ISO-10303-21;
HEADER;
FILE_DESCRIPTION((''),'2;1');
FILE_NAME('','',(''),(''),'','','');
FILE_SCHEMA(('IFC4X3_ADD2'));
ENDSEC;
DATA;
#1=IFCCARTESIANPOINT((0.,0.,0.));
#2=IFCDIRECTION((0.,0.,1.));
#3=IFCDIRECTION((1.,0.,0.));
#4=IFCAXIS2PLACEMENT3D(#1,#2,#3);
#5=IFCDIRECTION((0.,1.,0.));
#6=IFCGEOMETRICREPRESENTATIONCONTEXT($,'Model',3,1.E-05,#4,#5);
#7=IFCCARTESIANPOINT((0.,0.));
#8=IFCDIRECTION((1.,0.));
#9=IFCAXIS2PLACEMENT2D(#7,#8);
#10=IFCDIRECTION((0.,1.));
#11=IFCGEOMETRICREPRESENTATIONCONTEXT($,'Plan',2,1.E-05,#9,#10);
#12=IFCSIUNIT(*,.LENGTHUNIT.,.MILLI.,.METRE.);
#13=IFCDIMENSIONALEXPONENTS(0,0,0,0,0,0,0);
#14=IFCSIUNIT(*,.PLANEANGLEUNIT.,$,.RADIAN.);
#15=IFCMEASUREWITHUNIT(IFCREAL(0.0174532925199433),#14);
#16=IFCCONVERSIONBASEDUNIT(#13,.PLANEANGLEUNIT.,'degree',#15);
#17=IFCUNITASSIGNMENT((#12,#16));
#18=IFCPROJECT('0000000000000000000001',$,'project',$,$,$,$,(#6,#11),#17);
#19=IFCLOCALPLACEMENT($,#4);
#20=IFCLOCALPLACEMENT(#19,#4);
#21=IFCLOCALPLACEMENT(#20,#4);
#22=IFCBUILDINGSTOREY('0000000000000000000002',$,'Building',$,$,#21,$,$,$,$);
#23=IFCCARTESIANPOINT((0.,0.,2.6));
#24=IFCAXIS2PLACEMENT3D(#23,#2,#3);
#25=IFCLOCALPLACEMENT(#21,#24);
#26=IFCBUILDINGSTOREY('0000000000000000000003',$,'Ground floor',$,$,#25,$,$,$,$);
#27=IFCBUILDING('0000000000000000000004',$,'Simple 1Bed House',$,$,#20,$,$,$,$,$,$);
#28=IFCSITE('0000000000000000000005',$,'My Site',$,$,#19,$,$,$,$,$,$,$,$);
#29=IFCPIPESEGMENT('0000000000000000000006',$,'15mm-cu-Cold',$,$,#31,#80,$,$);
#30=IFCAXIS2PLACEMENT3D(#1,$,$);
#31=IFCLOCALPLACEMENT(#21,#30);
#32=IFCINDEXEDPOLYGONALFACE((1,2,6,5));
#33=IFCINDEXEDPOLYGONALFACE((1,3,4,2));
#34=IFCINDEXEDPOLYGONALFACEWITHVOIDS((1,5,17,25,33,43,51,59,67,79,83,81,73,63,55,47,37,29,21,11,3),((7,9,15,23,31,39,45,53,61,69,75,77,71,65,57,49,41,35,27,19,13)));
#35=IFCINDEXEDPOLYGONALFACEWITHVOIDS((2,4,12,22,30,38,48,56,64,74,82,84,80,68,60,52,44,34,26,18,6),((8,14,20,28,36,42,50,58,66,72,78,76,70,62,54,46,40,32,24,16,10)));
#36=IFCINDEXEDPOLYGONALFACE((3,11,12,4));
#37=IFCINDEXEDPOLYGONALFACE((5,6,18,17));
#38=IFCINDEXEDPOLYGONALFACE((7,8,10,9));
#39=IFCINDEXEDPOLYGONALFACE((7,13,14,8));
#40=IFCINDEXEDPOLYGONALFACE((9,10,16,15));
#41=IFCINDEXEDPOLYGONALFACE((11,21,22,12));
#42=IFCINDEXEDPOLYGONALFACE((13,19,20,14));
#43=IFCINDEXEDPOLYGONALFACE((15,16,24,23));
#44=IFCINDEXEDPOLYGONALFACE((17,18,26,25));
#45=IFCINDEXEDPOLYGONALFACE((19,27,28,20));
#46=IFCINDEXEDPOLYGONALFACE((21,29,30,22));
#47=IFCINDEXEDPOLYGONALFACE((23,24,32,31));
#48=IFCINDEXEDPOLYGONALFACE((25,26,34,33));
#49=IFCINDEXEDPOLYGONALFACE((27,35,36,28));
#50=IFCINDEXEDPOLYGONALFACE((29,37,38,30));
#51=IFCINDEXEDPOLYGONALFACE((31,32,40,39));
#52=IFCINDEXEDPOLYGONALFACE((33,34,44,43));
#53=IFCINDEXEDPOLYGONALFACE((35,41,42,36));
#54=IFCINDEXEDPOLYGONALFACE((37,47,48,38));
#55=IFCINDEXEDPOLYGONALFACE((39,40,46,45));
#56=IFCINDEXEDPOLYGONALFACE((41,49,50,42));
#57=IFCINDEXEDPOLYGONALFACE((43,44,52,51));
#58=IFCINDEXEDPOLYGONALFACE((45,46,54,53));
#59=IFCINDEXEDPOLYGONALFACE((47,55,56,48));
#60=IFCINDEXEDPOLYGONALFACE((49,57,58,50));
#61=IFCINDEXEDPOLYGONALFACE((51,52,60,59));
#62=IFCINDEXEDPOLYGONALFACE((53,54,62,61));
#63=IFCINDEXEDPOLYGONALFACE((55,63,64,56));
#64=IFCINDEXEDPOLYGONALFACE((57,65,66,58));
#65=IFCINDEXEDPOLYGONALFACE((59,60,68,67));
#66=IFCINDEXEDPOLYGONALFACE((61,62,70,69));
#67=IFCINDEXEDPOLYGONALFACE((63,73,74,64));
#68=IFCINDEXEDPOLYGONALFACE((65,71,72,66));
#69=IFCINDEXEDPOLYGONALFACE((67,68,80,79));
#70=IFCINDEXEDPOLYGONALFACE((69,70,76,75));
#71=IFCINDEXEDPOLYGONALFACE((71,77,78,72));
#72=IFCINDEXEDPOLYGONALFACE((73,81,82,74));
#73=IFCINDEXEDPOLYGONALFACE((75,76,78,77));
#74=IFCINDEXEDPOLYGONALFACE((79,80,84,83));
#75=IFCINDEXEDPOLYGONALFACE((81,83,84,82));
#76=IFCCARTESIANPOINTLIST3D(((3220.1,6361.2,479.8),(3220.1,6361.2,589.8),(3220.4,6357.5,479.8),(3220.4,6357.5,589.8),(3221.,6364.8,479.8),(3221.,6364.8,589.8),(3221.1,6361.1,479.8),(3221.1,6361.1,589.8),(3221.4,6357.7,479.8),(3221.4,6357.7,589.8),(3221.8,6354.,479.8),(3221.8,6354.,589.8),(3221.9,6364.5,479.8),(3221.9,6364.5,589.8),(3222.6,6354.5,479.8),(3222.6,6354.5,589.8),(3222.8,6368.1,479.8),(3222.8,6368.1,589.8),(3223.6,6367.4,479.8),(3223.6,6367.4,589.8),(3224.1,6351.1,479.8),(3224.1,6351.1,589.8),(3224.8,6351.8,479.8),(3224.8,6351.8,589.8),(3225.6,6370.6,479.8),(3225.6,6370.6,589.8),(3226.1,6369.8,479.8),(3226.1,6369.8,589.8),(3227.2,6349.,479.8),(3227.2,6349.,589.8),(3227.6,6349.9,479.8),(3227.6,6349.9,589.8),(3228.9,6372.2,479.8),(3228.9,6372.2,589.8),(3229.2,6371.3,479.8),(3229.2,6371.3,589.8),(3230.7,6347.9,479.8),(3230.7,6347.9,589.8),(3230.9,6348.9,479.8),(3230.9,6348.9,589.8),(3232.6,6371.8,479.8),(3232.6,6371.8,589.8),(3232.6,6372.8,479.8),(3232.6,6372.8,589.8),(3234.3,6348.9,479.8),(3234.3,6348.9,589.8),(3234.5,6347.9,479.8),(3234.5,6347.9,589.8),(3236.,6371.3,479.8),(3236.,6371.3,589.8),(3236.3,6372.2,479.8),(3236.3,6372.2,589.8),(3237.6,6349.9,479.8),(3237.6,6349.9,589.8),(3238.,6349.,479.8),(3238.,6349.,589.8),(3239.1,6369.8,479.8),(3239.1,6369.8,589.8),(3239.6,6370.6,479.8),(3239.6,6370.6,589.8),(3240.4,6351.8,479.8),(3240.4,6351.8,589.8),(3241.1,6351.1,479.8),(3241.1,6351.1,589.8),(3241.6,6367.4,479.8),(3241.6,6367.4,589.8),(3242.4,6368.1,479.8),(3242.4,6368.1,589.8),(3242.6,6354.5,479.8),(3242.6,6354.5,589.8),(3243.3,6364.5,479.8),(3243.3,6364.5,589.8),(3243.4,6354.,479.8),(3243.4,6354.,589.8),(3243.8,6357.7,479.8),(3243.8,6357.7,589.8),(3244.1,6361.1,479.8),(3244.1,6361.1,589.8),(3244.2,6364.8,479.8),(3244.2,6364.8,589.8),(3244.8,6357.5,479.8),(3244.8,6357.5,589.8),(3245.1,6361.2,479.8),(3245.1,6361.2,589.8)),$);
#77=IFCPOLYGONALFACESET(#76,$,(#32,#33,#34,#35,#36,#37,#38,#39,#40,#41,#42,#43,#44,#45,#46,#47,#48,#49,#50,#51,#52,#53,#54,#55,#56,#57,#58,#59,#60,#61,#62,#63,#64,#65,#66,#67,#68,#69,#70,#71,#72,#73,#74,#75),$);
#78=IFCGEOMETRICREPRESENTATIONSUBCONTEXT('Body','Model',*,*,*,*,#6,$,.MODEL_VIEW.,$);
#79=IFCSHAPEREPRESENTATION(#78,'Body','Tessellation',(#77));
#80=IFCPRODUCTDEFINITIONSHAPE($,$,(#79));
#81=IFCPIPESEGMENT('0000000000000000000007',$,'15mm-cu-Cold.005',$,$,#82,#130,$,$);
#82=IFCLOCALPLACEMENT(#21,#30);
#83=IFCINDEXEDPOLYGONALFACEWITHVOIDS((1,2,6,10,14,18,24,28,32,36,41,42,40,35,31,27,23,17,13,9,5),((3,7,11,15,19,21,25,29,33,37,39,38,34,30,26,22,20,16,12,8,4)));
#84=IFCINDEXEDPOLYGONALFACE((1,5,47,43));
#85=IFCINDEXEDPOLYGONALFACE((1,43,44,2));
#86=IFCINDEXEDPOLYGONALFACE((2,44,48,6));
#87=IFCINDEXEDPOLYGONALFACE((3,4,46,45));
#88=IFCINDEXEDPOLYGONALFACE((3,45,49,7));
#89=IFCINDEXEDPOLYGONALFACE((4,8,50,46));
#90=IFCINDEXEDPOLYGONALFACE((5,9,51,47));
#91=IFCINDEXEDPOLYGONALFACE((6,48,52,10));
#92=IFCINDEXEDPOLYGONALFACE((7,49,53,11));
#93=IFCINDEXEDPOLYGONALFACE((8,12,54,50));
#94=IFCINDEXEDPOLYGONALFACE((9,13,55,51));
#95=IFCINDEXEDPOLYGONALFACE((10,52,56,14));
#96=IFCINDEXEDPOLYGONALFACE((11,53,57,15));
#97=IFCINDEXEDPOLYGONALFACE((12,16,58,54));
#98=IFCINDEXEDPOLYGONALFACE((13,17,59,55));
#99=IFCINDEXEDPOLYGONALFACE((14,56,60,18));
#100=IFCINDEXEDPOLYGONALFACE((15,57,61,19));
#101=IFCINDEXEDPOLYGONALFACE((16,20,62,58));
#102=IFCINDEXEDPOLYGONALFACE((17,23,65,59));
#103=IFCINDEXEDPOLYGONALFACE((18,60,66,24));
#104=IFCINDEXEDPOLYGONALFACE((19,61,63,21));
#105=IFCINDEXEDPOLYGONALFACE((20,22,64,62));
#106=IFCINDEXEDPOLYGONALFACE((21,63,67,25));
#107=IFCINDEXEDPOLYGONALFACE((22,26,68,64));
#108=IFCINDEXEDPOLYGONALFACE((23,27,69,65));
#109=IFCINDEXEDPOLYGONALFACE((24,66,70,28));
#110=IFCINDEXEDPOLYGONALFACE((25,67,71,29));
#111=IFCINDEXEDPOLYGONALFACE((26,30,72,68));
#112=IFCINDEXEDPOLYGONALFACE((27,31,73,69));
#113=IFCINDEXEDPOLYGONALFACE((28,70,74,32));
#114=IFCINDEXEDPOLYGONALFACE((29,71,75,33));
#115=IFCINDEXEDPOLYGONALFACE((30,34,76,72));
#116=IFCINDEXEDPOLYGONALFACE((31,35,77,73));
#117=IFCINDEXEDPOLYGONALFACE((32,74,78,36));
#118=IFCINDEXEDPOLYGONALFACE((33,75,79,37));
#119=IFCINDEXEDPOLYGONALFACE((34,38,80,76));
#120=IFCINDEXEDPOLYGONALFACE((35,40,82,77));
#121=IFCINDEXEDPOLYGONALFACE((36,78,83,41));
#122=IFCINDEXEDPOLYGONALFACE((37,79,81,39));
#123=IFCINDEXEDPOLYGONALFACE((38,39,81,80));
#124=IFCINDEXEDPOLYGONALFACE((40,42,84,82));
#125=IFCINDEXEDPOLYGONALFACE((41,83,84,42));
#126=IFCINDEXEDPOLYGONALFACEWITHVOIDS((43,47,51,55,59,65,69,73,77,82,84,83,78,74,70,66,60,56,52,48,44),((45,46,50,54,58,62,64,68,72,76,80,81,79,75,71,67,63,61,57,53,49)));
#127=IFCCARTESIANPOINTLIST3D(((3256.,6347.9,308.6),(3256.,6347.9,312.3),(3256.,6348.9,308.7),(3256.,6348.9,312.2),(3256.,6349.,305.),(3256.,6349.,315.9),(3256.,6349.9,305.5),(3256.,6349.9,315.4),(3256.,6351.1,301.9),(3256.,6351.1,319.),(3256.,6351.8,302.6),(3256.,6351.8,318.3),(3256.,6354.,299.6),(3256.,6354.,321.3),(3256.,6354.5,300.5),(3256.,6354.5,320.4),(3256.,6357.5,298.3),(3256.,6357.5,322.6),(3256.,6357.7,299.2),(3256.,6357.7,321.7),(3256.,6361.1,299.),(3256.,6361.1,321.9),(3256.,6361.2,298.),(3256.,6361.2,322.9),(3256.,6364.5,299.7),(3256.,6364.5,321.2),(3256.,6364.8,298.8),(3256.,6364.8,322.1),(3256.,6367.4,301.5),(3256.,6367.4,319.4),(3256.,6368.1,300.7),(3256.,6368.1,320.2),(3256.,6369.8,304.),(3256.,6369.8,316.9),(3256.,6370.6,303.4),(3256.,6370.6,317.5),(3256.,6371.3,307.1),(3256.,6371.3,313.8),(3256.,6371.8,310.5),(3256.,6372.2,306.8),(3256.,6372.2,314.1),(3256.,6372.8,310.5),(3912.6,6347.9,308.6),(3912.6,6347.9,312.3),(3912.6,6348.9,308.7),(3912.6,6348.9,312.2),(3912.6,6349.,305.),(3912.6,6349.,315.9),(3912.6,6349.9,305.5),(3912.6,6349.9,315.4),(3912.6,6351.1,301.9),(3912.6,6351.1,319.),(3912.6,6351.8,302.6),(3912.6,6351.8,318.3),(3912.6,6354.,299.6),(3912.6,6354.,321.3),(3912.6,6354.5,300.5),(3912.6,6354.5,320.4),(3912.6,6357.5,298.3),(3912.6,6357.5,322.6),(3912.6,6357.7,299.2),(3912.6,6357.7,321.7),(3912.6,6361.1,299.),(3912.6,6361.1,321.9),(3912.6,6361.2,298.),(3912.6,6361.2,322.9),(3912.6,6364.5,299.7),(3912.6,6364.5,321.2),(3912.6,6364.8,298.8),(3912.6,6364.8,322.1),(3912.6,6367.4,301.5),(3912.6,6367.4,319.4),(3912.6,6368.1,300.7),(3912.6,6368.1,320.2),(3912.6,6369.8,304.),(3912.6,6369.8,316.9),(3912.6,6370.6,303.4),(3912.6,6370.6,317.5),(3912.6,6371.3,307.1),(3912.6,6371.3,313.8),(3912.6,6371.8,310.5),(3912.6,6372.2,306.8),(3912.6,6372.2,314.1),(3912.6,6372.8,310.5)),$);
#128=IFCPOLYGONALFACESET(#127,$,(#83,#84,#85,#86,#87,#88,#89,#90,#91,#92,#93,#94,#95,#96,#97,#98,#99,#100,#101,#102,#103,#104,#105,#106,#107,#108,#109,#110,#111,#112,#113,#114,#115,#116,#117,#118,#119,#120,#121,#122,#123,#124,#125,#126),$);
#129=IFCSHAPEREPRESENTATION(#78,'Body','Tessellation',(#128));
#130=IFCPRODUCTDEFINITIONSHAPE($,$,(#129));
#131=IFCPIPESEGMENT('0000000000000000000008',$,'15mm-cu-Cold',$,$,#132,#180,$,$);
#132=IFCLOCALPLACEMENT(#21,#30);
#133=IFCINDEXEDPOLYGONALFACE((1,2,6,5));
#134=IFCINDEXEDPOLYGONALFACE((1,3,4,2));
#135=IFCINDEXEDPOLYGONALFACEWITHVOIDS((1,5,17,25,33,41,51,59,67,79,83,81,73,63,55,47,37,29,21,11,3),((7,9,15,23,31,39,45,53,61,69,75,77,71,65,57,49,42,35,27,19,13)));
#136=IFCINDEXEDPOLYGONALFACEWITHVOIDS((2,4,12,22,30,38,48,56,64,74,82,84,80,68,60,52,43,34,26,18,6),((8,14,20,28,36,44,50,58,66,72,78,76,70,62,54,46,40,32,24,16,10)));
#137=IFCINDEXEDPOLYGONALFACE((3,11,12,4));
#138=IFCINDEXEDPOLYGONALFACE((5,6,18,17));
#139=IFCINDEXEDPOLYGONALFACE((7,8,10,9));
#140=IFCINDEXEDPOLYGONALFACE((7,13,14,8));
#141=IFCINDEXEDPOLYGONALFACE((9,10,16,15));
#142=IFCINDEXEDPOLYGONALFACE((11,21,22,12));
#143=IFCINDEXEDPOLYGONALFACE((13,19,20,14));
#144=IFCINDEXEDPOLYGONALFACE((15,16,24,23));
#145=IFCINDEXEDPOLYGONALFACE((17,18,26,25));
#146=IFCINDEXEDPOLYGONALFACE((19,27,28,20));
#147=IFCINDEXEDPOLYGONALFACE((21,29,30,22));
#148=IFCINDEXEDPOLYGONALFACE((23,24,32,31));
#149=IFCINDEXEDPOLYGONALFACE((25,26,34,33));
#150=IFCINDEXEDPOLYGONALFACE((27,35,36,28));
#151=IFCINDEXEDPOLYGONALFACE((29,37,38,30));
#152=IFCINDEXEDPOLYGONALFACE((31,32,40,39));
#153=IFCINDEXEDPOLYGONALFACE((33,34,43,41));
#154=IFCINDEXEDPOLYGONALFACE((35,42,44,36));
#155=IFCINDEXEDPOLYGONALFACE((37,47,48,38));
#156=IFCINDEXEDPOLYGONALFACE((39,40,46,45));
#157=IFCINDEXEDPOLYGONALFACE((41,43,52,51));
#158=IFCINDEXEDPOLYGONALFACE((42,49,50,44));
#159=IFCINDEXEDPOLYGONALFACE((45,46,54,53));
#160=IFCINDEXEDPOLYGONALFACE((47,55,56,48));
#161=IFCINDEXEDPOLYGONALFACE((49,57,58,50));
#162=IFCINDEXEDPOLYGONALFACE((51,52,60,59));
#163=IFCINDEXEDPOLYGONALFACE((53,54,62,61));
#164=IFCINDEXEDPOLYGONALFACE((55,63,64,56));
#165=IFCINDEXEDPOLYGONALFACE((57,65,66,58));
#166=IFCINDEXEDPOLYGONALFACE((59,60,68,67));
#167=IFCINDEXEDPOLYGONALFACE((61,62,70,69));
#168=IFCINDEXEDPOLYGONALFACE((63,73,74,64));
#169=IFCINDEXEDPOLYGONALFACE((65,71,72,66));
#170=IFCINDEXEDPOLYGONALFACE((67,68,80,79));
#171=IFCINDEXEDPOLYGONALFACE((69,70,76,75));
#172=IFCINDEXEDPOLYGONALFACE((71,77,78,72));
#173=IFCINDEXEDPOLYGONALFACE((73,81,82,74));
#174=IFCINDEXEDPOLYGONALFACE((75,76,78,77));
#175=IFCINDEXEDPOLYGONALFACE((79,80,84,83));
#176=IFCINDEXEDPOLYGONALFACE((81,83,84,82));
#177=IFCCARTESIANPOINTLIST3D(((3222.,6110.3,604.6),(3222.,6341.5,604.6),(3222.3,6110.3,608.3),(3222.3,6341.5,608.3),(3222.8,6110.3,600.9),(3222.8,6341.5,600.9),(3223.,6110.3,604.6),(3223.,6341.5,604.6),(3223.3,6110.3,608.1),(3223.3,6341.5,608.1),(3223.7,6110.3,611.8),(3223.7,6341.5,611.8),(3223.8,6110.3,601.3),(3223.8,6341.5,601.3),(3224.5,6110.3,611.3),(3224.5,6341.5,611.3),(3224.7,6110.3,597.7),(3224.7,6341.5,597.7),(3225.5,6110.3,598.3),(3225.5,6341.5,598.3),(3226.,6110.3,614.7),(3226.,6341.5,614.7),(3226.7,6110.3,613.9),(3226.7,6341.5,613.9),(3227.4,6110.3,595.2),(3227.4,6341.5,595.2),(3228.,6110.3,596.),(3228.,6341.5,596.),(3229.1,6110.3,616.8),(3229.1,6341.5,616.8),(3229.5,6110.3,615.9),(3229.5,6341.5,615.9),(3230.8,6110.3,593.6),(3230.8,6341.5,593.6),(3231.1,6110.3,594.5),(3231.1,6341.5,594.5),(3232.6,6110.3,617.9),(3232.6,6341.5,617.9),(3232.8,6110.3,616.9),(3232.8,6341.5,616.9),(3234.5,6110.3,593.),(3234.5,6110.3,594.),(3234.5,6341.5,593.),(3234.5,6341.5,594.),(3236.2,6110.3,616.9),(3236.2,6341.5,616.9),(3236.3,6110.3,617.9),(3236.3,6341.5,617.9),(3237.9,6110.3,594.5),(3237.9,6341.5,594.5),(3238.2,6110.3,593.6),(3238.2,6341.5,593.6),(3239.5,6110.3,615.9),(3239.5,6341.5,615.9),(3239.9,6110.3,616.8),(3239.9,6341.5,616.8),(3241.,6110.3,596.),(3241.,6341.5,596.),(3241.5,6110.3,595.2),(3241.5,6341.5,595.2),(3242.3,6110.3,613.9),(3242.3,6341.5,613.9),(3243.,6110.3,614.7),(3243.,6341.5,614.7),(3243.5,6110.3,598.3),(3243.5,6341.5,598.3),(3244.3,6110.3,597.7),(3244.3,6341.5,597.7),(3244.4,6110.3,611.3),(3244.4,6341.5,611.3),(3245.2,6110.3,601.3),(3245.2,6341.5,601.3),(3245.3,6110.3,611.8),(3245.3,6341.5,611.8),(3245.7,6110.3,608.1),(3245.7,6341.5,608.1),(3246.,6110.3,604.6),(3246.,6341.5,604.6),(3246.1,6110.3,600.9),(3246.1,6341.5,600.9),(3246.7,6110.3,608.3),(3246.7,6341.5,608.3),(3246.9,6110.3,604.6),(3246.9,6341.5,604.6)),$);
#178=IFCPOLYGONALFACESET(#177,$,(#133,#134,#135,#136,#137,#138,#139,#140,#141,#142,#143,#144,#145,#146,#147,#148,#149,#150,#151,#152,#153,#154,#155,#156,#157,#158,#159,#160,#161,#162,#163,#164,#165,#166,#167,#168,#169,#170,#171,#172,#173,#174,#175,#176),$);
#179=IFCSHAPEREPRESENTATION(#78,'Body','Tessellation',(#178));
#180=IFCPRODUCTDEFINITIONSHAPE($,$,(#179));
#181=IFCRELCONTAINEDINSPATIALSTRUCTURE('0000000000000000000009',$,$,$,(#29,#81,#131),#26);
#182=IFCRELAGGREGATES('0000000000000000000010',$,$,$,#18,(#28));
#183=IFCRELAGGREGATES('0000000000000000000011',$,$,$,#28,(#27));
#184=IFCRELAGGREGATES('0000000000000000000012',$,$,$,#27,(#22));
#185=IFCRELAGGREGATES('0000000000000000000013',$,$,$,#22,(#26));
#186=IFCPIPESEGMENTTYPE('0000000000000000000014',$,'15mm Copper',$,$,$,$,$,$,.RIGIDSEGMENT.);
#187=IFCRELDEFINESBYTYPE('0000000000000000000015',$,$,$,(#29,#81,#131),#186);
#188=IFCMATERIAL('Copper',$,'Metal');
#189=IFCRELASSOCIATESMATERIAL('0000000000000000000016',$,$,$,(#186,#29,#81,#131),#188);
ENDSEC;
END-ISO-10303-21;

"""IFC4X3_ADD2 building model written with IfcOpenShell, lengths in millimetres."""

from ifc_helpers import new_model, entity, si_unit, converted_unit, direction, frame, origin_with_axes, origin_2d_with_axis, place, context, subcontext, project, spatial, hollow_circle, extrude, material, material_profile, profile_set, profile_usage, type_object, element, save


model = new_model("IFC4X3_ADD2")

# Units and contexts
model_context = context("Model", 3, precision=1e-05, world=origin_with_axes(), true_north=direction((0.0, 1.0, 0.0)))
plan_context = context("Plan", 2, precision=1e-05, world=origin_2d_with_axis(), true_north=direction((0.0, 1.0)))
body_context_1 = subcontext(model_context, "Body", "Model", "MODEL_VIEW")
ifc_project = project(units=[si_unit("LENGTHUNIT", "METRE", prefix="MILLI"), converted_unit("PLANEANGLEUNIT", "degree", entity("IfcReal", 0.0174532925199433), si_unit("PLANEANGLEUNIT", "RADIAN"), dimensions=[0, 0, 0, 0, 0, 0, 0])], contexts=[model_context, plan_context])

# Site, building, storeys
site_placement = place(None, origin_with_axes())
site = spatial("IfcSite", under=ifc_project, at=site_placement, Name="My Site")
building_placement = place(site_placement, origin_with_axes())
building = spatial("IfcBuilding", under=site, at=building_placement, Name="Simple 1Bed House")
storey_1_placement = place(building_placement, origin_with_axes())
storey_1 = spatial("IfcBuildingStorey", under=building, at=storey_1_placement, Name="Building")
storey_2_placement = place(storey_1_placement, frame((0.0, 0.0, 2.6), z_axis=(0.0, 0.0, 1.0), x_axis=(1.0, 0.0, 0.0)))
storey_2 = spatial("IfcBuildingStorey", under=storey_1, at=storey_2_placement, Name="Ground floor")

# Pipe segments
ifc_material_1 = material(Name="Copper", Category="Metal")
ifc_material_profile_1 = material_profile(ifc_material_1, hollow_circle(Radius=12.5, WallThickness=1.0))
ifc_profile_set_1 = profile_set([ifc_material_profile_1])
pipe_segment_type_1 = type_object("IfcPipeSegmentType", Name="15mm Copper", PredefinedType="RIGIDSEGMENT", material=ifc_profile_set_1)
ifc_profile_usage_1 = profile_usage(ifc_profile_set_1, cardinal=5)
pipe_segment_1_placement = place(storey_2_placement, frame((3232.6, 6360.3, 587.2), z_axis=(0.0, 0.0, -1.0), x_axis=(0.0, 1.0, 0.0)))
element("IfcPipeSegment", 1, at=pipe_segment_1_placement, inside=storey_2, type_object=pipe_segment_type_1, material=ifc_profile_usage_1, Name="15mm-cu-Cold", context=body_context_1, shape_type="SweptSolid", body=[
    extrude(hollow_circle(Radius=12.5, WallThickness=1.0), origin_with_axes(), (0.0, 0.0, 1.0), 110.0),
])
ifc_profile_usage_2 = profile_usage(ifc_profile_set_1, cardinal=5)
pipe_segment_2_placement = place(storey_2_placement, frame((3256.0, 6360.3, 307.9), z_axis=(1.0, 0.0, 0.0), x_axis=(0.0, 1.0, 0.0)))
element("IfcPipeSegment", 2, at=pipe_segment_2_placement, inside=storey_2, type_object=pipe_segment_type_1, material=ifc_profile_usage_2, Name="15mm-cu-Cold.005", context=body_context_1, shape_type="SweptSolid", body=[
    extrude(hollow_circle(Radius=12.5, WallThickness=1.0), origin_with_axes(), (0.0, 0.0, 1.0), 656.5),
])
ifc_profile_usage_3 = profile_usage(ifc_profile_set_1, cardinal=5)
pipe_segment_3_placement = place(storey_2_placement, frame((3234.5, 6341.5, 602.9), z_axis=(0.0, -1.0, 0.0), x_axis=(0.0, 0.0, -1.0)))
element("IfcPipeSegment", 3, at=pipe_segment_3_placement, inside=storey_2, type_object=pipe_segment_type_1, material=ifc_profile_usage_3, Name="15mm-cu-Cold", context=body_context_1, shape_type="SweptSolid", body=[
    extrude(hollow_circle(Radius=12.5, WallThickness=1.0), origin_with_axes(), (0.0, 0.0, 1.0), 231.3),
])

save(model, "model.ifc")
